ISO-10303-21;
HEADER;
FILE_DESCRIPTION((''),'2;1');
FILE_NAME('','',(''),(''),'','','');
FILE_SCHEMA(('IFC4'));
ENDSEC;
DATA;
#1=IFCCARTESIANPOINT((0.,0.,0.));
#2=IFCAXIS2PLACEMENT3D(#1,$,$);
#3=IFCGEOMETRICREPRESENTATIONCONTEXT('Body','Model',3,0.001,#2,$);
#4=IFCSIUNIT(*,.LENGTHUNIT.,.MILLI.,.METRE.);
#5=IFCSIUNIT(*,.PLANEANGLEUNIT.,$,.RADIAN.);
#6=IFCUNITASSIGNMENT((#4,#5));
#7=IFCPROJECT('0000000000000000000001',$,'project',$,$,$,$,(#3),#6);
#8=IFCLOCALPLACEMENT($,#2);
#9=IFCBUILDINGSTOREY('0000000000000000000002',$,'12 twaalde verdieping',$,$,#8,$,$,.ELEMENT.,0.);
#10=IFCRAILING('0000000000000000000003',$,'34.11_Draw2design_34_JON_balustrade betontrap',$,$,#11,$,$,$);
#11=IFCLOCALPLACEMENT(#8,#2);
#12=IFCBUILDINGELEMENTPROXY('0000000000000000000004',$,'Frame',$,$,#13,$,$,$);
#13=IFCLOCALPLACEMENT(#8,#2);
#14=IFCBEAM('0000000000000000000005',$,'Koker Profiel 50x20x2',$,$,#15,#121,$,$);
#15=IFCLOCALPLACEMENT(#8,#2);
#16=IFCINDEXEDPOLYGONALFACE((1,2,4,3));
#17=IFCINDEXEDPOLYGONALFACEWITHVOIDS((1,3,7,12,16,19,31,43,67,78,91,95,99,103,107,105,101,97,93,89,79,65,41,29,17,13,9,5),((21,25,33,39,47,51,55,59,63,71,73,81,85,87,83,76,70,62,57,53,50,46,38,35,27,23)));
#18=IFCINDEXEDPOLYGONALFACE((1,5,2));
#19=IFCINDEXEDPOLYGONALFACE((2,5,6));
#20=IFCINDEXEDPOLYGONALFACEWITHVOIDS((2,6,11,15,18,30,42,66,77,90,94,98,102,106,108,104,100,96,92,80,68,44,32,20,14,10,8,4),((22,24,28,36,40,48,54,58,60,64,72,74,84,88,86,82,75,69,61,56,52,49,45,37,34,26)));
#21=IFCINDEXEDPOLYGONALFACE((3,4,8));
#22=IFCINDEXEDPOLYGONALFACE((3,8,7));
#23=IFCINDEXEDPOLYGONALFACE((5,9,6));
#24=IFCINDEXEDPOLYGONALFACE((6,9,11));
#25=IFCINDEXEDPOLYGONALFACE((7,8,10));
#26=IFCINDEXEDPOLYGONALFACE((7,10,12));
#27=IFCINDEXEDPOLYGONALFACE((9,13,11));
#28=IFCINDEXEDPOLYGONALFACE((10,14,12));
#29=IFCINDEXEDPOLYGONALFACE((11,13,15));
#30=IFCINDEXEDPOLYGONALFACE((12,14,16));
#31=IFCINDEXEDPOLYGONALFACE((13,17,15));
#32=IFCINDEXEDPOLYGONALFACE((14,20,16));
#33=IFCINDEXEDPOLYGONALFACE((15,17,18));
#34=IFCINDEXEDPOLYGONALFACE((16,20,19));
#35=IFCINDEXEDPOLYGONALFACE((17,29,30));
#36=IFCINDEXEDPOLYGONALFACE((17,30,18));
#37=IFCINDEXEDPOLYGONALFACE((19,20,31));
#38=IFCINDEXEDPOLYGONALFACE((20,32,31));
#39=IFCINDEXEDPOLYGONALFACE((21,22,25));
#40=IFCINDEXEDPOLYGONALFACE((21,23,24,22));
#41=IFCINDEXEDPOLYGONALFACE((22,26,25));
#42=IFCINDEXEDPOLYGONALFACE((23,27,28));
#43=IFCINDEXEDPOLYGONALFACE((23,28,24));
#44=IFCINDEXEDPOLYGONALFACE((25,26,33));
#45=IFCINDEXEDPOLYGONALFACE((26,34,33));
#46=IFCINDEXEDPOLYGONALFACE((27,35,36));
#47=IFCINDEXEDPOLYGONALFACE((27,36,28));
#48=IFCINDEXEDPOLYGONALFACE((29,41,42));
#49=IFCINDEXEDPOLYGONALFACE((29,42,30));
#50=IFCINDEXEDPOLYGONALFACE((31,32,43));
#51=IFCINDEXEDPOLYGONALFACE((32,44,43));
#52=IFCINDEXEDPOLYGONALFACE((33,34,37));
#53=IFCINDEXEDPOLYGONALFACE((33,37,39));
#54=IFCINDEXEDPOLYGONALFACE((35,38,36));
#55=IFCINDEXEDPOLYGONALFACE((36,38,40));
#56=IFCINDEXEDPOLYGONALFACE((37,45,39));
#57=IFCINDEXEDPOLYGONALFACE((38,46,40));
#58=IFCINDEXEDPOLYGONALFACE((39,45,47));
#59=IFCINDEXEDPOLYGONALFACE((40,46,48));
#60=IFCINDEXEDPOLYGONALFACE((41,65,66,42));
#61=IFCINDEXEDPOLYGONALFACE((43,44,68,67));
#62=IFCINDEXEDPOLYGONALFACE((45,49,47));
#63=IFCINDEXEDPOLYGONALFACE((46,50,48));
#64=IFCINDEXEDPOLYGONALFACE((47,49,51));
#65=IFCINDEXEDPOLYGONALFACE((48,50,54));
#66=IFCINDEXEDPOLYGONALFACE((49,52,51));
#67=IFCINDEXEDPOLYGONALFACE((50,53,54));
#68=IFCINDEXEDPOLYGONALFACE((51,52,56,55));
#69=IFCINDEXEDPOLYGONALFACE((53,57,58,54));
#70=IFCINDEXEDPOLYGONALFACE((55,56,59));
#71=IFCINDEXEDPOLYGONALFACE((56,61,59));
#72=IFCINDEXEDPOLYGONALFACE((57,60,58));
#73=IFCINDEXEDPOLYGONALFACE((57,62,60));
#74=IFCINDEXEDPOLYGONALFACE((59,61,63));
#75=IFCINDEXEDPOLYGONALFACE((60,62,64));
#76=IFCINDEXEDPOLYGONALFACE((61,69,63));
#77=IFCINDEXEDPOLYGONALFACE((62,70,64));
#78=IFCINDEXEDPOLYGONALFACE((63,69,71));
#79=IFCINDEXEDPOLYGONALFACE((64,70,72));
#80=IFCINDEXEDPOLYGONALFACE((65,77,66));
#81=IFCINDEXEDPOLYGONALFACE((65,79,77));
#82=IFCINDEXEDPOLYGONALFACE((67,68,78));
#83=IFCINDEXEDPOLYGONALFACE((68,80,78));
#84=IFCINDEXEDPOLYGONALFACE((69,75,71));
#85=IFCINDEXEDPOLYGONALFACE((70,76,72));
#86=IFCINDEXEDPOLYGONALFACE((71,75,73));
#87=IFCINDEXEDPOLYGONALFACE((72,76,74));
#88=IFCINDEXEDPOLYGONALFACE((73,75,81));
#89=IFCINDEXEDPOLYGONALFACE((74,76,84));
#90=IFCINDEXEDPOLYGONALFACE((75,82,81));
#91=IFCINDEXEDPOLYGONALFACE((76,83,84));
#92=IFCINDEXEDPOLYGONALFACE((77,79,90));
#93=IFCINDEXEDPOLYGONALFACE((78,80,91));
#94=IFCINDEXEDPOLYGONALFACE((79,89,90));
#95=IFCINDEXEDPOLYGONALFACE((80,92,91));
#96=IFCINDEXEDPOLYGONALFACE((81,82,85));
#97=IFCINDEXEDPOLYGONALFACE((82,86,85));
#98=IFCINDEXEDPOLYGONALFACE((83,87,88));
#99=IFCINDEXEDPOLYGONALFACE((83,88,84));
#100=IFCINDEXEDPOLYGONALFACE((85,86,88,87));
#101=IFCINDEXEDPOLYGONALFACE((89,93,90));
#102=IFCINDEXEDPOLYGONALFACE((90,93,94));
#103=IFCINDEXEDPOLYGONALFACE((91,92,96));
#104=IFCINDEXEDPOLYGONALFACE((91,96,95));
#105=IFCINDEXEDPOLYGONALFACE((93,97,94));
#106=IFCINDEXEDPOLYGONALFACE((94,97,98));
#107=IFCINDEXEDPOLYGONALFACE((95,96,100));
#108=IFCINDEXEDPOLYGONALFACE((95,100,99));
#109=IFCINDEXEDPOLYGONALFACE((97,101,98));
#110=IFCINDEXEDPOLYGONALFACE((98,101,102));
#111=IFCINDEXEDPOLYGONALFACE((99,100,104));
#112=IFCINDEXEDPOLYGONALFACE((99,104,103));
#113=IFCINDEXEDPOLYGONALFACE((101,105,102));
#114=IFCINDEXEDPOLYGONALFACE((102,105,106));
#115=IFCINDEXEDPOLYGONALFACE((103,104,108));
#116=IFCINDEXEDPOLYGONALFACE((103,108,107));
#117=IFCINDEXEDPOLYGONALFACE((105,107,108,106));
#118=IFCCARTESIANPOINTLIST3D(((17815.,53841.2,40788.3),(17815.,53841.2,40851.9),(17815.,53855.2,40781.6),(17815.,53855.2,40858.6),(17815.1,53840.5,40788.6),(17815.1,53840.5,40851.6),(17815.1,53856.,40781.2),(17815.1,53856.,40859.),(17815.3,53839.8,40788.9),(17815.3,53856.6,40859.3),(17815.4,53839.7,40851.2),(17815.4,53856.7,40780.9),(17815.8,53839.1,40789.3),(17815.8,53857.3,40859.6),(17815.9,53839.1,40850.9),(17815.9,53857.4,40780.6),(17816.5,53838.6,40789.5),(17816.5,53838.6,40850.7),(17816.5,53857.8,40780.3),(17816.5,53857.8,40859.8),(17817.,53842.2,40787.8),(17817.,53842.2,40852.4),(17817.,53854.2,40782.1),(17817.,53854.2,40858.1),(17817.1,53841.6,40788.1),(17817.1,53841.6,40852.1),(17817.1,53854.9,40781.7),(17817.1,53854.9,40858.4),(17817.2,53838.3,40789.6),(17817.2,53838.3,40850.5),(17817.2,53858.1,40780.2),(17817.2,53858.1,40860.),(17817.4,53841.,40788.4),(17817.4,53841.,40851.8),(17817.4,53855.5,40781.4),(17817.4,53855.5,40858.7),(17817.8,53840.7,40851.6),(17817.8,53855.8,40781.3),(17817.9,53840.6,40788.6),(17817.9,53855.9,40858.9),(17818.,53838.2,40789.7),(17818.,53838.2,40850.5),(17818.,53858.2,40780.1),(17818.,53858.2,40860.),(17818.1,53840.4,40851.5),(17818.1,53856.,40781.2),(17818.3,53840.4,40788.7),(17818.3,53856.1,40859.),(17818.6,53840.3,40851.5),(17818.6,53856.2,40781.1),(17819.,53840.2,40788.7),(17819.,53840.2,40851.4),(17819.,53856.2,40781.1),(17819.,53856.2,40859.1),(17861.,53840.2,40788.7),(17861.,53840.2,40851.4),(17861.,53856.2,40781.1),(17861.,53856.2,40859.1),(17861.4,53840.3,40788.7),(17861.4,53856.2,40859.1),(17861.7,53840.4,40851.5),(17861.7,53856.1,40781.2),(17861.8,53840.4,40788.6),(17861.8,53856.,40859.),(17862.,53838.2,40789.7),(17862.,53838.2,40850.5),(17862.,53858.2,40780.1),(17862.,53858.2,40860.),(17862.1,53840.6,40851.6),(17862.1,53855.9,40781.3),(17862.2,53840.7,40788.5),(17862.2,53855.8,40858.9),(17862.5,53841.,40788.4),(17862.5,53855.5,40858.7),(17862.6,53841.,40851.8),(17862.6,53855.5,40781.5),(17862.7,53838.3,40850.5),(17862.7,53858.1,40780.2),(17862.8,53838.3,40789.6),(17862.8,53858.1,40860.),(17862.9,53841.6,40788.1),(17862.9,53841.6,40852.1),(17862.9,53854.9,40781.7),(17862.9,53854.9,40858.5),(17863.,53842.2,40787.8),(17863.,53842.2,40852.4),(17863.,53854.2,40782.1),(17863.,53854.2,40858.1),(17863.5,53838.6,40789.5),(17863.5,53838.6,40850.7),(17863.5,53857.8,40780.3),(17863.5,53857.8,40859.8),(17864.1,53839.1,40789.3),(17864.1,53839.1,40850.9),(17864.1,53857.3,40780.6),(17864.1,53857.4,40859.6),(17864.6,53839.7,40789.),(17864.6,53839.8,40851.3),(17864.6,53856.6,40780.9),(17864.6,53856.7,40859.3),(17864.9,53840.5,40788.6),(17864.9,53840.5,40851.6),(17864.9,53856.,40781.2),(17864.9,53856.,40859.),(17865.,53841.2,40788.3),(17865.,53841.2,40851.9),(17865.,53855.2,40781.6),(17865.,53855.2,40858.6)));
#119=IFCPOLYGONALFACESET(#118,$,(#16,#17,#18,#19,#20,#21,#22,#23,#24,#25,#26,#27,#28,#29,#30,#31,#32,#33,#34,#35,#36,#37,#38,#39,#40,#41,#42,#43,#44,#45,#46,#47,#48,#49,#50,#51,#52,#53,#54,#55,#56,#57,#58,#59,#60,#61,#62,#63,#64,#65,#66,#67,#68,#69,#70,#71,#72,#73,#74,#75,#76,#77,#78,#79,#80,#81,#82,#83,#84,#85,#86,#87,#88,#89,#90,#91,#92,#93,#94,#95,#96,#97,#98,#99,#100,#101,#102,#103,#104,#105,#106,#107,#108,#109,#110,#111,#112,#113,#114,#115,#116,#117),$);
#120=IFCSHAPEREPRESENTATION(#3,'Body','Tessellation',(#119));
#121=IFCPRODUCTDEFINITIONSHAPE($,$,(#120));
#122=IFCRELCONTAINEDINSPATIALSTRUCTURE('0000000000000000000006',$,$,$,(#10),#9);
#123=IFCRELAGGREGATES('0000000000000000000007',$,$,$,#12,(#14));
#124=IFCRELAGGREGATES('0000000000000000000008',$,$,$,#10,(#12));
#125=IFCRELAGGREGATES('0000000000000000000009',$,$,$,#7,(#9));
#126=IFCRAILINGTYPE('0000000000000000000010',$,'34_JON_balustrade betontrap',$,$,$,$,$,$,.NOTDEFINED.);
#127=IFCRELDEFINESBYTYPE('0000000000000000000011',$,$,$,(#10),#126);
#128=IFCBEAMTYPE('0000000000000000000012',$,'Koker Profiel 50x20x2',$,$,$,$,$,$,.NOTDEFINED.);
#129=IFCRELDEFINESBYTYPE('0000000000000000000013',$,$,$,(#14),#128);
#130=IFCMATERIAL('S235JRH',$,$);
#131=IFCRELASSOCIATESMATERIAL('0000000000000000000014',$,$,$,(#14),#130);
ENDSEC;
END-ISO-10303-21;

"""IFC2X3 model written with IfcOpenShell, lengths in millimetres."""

from ifc_helpers import new_model, si_unit, frame, origin, origin_2d, place, context, project, spatial, hollow_rectangle, extrude, clip, halfspace, source, transform, mapped, material, type_object, element, aggregate, save


model = new_model("IFC2X3")

# Units and contexts
model_context = context("Model", 3, precision=0.001, world=origin(), identifier="Body")
ifc_project = project(units=[si_unit("LENGTHUNIT", "METRE", prefix="MILLI"), si_unit("PLANEANGLEUNIT", "RADIAN")], contexts=[model_context])

# Storey
storey_placement = place(None, origin())
storey = spatial("IfcBuildingStorey", under=ifc_project, at=storey_placement, Name="12 twaalde verdieping", CompositionType="ELEMENT", Elevation=0.0)

# Railing, building element proxy, beam
railing_type = type_object("IfcRailingType", Name="34_JON_balustrade betontrap")
railing_placement = place(storey_placement, frame((-2939.5, 7875.7, -8104.2), z_axis=(0.0, 0.0, 1.0), x_axis=(1.0, 0.0, 0.0)))
railing = element("IfcRailing", 1, at=railing_placement, inside=storey, type_object=railing_type, Name="34.11_Draw2design_34_JON_balustrade betontrap")
ifc_material_1 = material(Name="S235JRH")
proxy_1_placement = place(railing_placement, origin())
proxy_1 = element("IfcBuildingElementProxy", 2, at=proxy_1_placement, Name="Frame")
beam_type_1 = type_object("IfcBeamType", Name="Koker Profiel 50x20x2")
shared_shape_1 = source(origin(), model_context, "Body", "Clipping", [
    clip(clip(extrude(hollow_rectangle(XDim=20.0, YDim=50.0, WallThickness=2.0, InnerFilletRadius=2.0, OuterFilletRadius=3.0, at=origin_2d()), origin(), (0.0, 0.0, -1.0), 79.9), halfspace(frame((-10.0, 25.0, -9.6), z_axis=(-0.430948, 0.0, 0.902377), x_axis=(0.902377, 0.0, 0.430948)), False)), halfspace(frame((-10.0, -25.0, -70.3), z_axis=(-0.430948, 0.0, -0.902377), x_axis=(-0.902377, 0.0, 0.430948)), False)),
])
beam_1_placement = place(proxy_1_placement, frame((20779.5, 45972.5, 48964.2), z_axis=(0.0, 0.0, 1.0), x_axis=(0.0, 1.0, 0.0)))
beam_1 = element("IfcBeam", 3, at=beam_1_placement, type_object=beam_type_1, material=ifc_material_1, Name="Koker Profiel 50x20x2", context=model_context, shape_type="MappedRepresentation", body=[
    mapped(shared_shape_1, transform((0.0, 0.0, 0.0), scale=1.0)),
])
aggregate(proxy_1, [beam_1])
aggregate(railing, [proxy_1])

save(model, "model.ifc")
